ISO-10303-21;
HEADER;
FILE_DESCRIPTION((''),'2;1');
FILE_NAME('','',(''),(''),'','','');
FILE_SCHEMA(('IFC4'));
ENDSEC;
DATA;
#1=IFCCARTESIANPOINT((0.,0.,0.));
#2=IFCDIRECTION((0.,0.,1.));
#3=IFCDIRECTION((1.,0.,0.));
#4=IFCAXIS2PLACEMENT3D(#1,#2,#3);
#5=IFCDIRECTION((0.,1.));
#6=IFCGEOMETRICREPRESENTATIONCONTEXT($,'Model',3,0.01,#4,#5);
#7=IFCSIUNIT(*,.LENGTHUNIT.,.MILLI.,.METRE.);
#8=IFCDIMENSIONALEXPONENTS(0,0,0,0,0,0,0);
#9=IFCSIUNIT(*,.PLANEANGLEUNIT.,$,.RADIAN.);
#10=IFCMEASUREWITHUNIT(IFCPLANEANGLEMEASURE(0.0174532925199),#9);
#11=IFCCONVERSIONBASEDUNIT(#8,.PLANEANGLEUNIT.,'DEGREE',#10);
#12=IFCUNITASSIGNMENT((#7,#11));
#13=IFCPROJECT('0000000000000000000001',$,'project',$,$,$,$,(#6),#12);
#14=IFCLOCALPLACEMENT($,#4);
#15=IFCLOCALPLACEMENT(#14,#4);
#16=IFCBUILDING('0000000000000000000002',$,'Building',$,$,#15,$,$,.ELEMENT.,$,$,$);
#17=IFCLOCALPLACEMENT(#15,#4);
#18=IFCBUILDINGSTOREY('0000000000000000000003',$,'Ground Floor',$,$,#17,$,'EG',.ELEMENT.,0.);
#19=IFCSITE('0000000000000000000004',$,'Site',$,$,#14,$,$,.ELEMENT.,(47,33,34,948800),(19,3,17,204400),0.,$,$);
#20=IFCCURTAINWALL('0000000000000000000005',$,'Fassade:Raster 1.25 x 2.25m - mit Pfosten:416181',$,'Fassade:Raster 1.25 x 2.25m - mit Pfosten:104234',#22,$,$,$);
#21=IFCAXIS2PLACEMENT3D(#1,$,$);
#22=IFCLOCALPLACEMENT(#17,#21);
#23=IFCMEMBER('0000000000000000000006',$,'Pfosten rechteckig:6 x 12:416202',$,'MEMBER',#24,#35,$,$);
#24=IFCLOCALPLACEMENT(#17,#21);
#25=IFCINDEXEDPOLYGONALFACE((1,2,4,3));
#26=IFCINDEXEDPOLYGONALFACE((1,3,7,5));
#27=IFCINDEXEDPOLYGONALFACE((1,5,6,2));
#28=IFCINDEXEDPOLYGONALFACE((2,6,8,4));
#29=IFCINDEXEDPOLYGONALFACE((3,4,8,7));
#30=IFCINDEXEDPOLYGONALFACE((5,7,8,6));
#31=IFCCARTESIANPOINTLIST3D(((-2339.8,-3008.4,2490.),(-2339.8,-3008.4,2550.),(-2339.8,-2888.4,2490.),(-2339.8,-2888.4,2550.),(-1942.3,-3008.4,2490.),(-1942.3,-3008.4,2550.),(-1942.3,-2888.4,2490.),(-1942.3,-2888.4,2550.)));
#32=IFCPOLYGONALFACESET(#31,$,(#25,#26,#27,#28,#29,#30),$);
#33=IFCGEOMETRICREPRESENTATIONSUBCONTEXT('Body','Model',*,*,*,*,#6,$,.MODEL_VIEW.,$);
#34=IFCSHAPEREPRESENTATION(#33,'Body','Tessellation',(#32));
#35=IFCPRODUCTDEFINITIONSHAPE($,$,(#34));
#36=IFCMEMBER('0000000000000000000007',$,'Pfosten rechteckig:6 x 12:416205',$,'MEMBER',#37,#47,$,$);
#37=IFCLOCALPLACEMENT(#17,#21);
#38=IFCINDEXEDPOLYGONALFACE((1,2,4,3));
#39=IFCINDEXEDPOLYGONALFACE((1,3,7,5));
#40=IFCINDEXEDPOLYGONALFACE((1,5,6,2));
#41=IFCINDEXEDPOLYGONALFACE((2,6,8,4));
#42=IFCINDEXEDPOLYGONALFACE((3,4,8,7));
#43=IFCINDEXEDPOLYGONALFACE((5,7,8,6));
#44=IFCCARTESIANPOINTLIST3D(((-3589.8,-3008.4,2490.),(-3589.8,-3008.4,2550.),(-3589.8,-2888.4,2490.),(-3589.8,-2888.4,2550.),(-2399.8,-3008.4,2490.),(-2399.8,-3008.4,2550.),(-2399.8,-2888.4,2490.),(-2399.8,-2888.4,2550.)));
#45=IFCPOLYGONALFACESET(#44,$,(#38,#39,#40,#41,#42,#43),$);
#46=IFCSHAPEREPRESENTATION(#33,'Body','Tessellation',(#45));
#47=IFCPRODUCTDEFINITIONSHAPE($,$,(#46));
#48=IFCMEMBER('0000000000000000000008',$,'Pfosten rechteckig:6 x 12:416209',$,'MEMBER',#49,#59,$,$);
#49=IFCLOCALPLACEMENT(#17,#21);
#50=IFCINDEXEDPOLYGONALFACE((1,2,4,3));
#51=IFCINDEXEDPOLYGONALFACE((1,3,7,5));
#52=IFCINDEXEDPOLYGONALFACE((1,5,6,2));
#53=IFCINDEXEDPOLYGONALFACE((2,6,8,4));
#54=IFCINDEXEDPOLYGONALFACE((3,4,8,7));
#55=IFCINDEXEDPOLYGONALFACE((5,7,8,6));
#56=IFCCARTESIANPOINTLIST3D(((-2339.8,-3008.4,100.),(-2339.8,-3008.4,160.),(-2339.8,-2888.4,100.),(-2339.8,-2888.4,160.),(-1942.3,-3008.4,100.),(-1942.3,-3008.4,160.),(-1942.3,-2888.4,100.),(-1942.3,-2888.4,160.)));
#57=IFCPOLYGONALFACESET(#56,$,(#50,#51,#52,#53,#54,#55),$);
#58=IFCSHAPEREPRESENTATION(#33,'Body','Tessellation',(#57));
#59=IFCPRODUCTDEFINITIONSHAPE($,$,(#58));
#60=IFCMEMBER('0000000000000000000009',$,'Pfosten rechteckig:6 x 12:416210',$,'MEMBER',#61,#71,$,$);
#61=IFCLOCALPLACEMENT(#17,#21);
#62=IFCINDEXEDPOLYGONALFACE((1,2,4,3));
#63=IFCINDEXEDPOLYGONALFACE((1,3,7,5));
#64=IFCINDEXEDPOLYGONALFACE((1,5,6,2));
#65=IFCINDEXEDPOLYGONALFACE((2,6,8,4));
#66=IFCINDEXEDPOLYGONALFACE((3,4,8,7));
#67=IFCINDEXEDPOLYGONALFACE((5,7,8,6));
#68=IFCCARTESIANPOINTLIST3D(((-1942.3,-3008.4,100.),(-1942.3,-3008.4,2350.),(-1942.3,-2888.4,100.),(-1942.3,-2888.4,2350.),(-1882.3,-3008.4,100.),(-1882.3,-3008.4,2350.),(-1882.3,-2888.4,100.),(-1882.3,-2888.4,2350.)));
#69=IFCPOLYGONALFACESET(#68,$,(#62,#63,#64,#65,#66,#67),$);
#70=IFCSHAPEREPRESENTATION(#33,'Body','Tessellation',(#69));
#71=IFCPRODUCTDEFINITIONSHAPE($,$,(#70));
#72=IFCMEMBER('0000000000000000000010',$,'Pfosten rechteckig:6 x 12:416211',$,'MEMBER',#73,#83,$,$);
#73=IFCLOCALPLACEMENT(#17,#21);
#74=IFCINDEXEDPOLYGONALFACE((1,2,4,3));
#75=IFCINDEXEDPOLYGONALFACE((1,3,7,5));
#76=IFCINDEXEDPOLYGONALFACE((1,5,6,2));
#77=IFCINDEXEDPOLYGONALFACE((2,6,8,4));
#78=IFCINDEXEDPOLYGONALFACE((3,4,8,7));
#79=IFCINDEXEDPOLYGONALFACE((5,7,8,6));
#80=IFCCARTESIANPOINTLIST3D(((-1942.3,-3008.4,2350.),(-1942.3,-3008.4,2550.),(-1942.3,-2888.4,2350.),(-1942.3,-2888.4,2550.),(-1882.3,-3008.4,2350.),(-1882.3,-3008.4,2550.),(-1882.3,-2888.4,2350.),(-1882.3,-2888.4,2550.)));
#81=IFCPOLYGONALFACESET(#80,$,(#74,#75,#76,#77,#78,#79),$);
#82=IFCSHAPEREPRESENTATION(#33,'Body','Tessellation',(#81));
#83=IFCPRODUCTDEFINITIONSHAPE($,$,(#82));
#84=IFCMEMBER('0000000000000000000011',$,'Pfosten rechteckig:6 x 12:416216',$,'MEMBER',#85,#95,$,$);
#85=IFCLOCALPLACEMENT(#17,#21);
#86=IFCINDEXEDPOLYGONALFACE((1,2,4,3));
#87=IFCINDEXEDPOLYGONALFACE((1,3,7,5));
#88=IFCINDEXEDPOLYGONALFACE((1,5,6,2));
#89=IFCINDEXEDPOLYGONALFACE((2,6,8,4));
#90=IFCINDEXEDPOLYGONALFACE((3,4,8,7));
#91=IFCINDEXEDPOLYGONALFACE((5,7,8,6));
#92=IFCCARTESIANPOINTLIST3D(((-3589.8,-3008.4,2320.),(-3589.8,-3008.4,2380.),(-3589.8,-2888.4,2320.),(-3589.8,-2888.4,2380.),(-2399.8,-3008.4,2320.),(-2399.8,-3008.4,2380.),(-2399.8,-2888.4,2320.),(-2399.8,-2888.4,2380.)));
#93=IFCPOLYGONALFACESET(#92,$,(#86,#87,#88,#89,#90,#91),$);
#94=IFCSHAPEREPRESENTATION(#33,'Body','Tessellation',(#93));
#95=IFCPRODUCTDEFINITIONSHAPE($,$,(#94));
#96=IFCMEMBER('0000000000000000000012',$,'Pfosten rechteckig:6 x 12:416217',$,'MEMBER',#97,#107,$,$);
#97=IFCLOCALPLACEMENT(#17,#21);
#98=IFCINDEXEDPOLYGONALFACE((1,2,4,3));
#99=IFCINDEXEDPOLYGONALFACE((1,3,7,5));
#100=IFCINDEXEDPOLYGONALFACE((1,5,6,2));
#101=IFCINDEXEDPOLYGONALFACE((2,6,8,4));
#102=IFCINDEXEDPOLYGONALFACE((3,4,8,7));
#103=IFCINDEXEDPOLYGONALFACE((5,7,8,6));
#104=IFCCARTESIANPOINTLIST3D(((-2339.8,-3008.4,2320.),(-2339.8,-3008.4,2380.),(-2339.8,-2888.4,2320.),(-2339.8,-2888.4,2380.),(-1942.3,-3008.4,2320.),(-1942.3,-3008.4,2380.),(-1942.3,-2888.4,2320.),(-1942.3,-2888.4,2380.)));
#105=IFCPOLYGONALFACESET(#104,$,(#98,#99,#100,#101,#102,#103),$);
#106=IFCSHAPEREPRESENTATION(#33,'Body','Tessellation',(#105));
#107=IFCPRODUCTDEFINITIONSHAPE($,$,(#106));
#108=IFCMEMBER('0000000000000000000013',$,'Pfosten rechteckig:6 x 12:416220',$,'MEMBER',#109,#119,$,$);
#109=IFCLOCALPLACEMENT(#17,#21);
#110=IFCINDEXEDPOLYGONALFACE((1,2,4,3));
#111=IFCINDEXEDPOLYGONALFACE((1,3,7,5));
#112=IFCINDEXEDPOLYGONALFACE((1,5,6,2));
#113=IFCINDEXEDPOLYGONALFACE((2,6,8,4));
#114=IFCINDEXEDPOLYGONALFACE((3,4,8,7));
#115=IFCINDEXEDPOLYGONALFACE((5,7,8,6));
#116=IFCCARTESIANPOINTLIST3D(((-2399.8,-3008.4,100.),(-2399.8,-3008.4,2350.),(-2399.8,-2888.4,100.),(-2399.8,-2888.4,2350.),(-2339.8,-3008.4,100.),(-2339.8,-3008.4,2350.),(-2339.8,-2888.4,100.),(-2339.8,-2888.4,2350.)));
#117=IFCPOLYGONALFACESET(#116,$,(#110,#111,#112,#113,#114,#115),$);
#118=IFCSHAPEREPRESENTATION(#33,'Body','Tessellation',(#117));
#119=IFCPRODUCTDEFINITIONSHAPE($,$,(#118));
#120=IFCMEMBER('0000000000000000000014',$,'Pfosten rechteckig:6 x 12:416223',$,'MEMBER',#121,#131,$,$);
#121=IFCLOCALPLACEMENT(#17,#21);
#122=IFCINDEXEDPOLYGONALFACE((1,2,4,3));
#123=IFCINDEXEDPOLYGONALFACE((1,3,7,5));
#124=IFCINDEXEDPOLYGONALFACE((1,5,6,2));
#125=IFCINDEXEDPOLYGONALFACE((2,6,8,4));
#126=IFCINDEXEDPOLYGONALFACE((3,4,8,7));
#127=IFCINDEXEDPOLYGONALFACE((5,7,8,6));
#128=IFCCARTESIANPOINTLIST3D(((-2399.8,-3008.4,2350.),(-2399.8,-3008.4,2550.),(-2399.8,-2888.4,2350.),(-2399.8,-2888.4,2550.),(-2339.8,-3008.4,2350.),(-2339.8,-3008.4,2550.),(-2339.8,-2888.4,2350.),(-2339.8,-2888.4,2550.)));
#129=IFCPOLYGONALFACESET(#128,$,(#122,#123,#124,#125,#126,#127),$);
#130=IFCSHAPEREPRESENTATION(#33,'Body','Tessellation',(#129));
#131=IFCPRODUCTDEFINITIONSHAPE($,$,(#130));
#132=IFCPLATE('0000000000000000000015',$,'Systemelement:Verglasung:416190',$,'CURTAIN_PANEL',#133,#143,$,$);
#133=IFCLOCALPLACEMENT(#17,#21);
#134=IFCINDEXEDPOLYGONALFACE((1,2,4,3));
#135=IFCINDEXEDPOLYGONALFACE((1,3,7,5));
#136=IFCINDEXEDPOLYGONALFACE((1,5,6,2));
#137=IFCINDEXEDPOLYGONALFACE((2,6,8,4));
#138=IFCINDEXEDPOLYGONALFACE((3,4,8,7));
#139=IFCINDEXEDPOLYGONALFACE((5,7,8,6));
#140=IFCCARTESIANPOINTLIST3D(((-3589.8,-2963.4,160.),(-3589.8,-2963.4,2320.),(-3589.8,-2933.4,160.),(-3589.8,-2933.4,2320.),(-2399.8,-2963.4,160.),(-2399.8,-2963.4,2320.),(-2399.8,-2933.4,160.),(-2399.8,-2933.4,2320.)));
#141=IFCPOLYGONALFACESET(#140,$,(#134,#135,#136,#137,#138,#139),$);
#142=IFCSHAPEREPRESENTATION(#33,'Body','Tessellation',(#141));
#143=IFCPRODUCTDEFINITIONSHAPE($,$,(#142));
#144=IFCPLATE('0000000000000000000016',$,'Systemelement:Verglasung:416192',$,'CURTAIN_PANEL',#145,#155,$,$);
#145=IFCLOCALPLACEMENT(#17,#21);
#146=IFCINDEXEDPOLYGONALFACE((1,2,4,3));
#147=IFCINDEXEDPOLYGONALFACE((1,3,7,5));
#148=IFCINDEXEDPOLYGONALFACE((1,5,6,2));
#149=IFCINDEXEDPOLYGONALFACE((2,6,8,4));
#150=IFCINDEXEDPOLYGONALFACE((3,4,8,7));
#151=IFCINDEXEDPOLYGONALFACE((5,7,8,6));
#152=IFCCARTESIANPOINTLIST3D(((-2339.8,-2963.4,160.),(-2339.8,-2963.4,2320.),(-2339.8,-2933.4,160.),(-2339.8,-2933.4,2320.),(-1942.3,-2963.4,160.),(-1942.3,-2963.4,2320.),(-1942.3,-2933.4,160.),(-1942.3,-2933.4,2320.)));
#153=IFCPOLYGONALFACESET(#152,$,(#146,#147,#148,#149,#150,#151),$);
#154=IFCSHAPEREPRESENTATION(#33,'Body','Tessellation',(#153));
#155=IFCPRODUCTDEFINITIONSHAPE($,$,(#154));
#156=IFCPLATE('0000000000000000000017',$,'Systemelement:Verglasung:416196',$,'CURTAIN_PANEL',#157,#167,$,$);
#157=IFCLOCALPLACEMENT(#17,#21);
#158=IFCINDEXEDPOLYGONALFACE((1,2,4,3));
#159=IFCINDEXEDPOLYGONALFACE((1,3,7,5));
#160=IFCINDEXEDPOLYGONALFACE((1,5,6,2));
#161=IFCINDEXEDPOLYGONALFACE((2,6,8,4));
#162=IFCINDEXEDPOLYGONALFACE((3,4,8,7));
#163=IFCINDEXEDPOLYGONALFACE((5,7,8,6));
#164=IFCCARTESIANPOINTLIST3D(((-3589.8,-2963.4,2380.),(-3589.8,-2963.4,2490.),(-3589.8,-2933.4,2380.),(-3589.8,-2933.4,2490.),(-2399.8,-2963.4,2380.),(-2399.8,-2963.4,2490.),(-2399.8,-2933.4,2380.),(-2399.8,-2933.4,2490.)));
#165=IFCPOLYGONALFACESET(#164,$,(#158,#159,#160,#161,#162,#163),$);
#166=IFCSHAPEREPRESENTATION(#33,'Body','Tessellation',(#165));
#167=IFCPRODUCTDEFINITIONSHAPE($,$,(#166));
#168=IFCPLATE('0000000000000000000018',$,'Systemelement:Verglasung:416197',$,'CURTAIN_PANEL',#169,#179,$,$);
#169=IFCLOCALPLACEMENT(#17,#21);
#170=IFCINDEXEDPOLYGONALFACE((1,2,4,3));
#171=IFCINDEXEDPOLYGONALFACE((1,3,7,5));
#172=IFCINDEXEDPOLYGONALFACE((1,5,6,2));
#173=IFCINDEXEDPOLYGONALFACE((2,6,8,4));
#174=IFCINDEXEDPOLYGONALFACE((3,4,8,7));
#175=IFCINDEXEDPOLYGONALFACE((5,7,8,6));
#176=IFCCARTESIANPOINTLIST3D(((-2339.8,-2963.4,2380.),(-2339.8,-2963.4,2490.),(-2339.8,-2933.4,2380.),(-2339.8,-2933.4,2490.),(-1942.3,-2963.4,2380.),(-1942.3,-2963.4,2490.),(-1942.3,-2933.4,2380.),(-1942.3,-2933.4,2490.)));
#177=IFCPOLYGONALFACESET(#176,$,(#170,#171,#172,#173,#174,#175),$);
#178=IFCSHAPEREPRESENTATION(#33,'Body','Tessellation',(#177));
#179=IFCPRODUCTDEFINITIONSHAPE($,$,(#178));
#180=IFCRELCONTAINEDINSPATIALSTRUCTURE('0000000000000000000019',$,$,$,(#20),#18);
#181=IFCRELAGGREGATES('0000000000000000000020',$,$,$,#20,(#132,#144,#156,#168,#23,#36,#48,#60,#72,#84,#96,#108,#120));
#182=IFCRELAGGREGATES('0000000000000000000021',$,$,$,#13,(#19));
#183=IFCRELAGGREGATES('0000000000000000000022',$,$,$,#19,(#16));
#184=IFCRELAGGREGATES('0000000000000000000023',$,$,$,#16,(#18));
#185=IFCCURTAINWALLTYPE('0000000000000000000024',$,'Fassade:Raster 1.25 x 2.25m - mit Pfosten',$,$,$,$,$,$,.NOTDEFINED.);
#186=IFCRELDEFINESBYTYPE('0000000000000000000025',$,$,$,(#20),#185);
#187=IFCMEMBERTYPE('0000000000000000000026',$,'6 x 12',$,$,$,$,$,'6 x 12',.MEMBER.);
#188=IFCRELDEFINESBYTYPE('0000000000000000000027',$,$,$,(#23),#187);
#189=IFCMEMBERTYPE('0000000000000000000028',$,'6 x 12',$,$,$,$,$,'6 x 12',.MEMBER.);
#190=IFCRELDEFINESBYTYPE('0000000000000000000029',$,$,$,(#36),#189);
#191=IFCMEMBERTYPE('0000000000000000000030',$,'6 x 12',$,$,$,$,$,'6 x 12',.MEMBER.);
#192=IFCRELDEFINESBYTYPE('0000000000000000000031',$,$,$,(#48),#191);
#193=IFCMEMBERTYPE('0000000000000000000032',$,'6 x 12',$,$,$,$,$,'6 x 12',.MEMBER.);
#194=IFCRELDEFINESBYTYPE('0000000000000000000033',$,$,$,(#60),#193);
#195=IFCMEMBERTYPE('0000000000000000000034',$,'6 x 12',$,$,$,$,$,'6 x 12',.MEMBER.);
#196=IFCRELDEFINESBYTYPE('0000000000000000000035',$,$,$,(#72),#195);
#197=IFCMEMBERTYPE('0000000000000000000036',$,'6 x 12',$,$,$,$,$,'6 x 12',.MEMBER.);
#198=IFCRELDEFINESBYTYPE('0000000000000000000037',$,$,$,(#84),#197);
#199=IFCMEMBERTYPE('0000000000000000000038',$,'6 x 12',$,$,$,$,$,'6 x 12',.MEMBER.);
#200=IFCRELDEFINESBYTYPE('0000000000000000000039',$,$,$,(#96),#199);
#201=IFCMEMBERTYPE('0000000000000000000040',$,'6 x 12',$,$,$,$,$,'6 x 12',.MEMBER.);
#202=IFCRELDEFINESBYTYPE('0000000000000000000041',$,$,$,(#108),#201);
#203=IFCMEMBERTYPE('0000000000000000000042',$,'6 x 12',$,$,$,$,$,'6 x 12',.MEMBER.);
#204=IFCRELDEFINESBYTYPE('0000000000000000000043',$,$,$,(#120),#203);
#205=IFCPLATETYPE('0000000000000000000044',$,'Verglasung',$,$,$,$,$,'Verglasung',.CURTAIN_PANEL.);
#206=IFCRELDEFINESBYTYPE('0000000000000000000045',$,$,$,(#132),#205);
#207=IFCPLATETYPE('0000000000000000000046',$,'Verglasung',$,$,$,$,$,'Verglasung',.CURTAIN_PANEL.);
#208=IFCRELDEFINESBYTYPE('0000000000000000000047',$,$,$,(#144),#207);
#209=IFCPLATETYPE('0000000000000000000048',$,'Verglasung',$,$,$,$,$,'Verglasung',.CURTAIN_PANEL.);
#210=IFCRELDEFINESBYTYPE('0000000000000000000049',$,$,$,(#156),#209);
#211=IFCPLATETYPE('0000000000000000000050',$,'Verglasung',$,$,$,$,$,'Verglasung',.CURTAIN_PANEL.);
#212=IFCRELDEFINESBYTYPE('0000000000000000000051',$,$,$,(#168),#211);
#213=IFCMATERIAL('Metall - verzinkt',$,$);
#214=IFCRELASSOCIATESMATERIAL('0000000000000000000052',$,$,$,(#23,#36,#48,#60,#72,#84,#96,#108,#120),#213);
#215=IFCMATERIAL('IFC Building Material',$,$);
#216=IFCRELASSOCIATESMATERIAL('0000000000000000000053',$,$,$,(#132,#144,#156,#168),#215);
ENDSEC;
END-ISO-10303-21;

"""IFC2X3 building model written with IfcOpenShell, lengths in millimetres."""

from ifc_helpers import new_model, entity, si_unit, converted_unit, direction, frame, origin_with_axes, origin_2d_with_axis, place, context, subcontext, project, spatial, rectangle, extrude, material, type_object, element, aggregate, save


model = new_model("IFC2X3")

# Units and contexts
model_context = context("Model", 3, precision=0.01, world=origin_with_axes(), true_north=direction((0.0, 1.0)))
body_context = subcontext(model_context, "Body", "Model", "MODEL_VIEW")
ifc_project = project(units=[si_unit("LENGTHUNIT", "METRE", prefix="MILLI"), converted_unit("PLANEANGLEUNIT", "DEGREE", entity("IfcPlaneAngleMeasure", 0.0174532925199), si_unit("PLANEANGLEUNIT", "RADIAN"), dimensions=[0, 0, 0, 0, 0, 0, 0])], contexts=[model_context])

# Site, building, storey
site_placement = place(None, origin_with_axes())
site = spatial("IfcSite", under=ifc_project, at=site_placement, Name="Site", CompositionType="ELEMENT", RefLatitude=(47, 33, 34, 948800), RefLongitude=(19, 3, 17, 204400), RefElevation=0.0)
building_placement = place(site_placement, origin_with_axes())
building = spatial("IfcBuilding", under=site, at=building_placement, Name="Building", CompositionType="ELEMENT")
storey_placement = place(building_placement, origin_with_axes())
storey = spatial("IfcBuildingStorey", under=building, at=storey_placement, Name="Ground Floor", LongName="EG", CompositionType="ELEMENT", Elevation=0.0)

# Curtain wall, members, plates
curtain_wall_type = type_object("IfcCurtainWallType", Name="Fassade:Raster 1.25 x 2.25m - mit Pfosten", PredefinedType="NOTDEFINED")
curtain_wall_placement = place(storey_placement, origin_with_axes())
curtain_wall = element("IfcCurtainWall", 1, at=curtain_wall_placement, inside=storey, type_object=curtain_wall_type, Name="Fassade:Raster 1.25 x 2.25m - mit Pfosten:416181", ObjectType="Fassade:Raster 1.25 x 2.25m - mit Pfosten:104234")
ifc_material_1 = material(Name="Metall - verzinkt")
member_type_1 = type_object("IfcMemberType", Name="6 x 12", ElementType="6 x 12", PredefinedType="MEMBER")
member_1_placement = place(curtain_wall_placement, frame((-1942.3, -2948.4, 2550.0), z_axis=(0.0, 0.0, 1.0), x_axis=(0.0, -1.0, 0.0)))
member_1 = element("IfcMember", 2, at=member_1_placement, type_object=member_type_1, material=ifc_material_1, Name="Pfosten rechteckig:6 x 12:416202", ObjectType="MEMBER", context=body_context, shape_type="SweptSolid", body=[
    extrude(rectangle(XDim=120.0, YDim=60.0, at=origin_2d_with_axis()), frame((0.0, -397.5, -30.0), z_axis=(0.0, 1.0, 0.0), x_axis=(-1.0, 0.0, 0.0)), (0.0, 0.0, 1.0), 397.5),
])
member_type_2 = type_object("IfcMemberType", Name="6 x 12", ElementType="6 x 12", PredefinedType="MEMBER")
member_2_placement = place(curtain_wall_placement, frame((-2399.8, -2948.4, 2550.0), z_axis=(0.0, 0.0, 1.0), x_axis=(0.0, -1.0, 0.0)))
member_2 = element("IfcMember", 3, at=member_2_placement, type_object=member_type_2, material=ifc_material_1, Name="Pfosten rechteckig:6 x 12:416205", ObjectType="MEMBER", context=body_context, shape_type="SweptSolid", body=[
    extrude(rectangle(XDim=120.0, YDim=60.0, at=origin_2d_with_axis()), frame((0.0, -1190.0, -30.0), z_axis=(0.0, 1.0, 0.0), x_axis=(-1.0, 0.0, 0.0)), (0.0, 0.0, 1.0), 1190.0),
])
member_type_3 = type_object("IfcMemberType", Name="6 x 12", ElementType="6 x 12", PredefinedType="MEMBER")
member_3_placement = place(curtain_wall_placement, frame((-2339.8, -2948.4, 100.0), z_axis=(0.0, 0.0, 1.0), x_axis=(0.0, -1.0, 0.0)))
member_3 = element("IfcMember", 4, at=member_3_placement, type_object=member_type_3, material=ifc_material_1, Name="Pfosten rechteckig:6 x 12:416209", ObjectType="MEMBER", context=body_context, shape_type="SweptSolid", body=[
    extrude(rectangle(XDim=120.0, YDim=60.0, at=origin_2d_with_axis()), frame((0.0, 397.5, 30.0), z_axis=(0.0, -1.0, 0.0), x_axis=(-1.0, 0.0, 0.0)), (0.0, 0.0, 1.0), 397.5),
])
member_type_4 = type_object("IfcMemberType", Name="6 x 12", ElementType="6 x 12", PredefinedType="MEMBER")
member_4_placement = place(curtain_wall_placement, frame((-1882.3, -2948.4, 100.0), z_axis=(0.0, 0.0, 1.0), x_axis=(1.0, 0.0, 0.0)))
member_4 = element("IfcMember", 5, at=member_4_placement, type_object=member_type_4, material=ifc_material_1, Name="Pfosten rechteckig:6 x 12:416210", ObjectType="MEMBER", context=body_context, shape_type="SweptSolid", body=[
    extrude(rectangle(XDim=120.0, YDim=60.0, at=origin_2d_with_axis()), frame((-30.0, 0.0, 2250.0), z_axis=(0.0, 0.0, -1.0), x_axis=(0.0, 1.0, 0.0)), (0.0, 0.0, 1.0), 2250.0),
])
member_type_5 = type_object("IfcMemberType", Name="6 x 12", ElementType="6 x 12", PredefinedType="MEMBER")
member_5_placement = place(curtain_wall_placement, frame((-1882.3, -2948.4, 2350.0), z_axis=(0.0, 0.0, 1.0), x_axis=(1.0, 0.0, 0.0)))
member_5 = element("IfcMember", 6, at=member_5_placement, type_object=member_type_5, material=ifc_material_1, Name="Pfosten rechteckig:6 x 12:416211", ObjectType="MEMBER", context=body_context, shape_type="SweptSolid", body=[
    extrude(rectangle(XDim=120.0, YDim=60.0, at=origin_2d_with_axis()), frame((-30.0, 0.0, 200.0), z_axis=(0.0, 0.0, -1.0), x_axis=(0.0, 1.0, 0.0)), (0.0, 0.0, 1.0), 200.0),
])
member_type_6 = type_object("IfcMemberType", Name="6 x 12", ElementType="6 x 12", PredefinedType="MEMBER")
member_6_placement = place(curtain_wall_placement, frame((-2399.8, -2948.4, 2350.0), z_axis=(0.0, 0.0, 1.0), x_axis=(0.0, -1.0, 0.0)))
member_6 = element("IfcMember", 7, at=member_6_placement, type_object=member_type_6, material=ifc_material_1, Name="Pfosten rechteckig:6 x 12:416216", ObjectType="MEMBER", context=body_context, shape_type="SweptSolid", body=[
    extrude(rectangle(XDim=120.0, YDim=60.0, at=origin_2d_with_axis()), frame((0.0, -1190.0, 0.0), z_axis=(0.0, 1.0, 0.0), x_axis=(-1.0, 0.0, 0.0)), (0.0, 0.0, 1.0), 1190.0),
])
member_type_7 = type_object("IfcMemberType", Name="6 x 12", ElementType="6 x 12", PredefinedType="MEMBER")
member_7_placement = place(curtain_wall_placement, frame((-1942.3, -2948.4, 2350.0), z_axis=(0.0, 0.0, 1.0), x_axis=(0.0, -1.0, 0.0)))
member_7 = element("IfcMember", 8, at=member_7_placement, type_object=member_type_7, material=ifc_material_1, Name="Pfosten rechteckig:6 x 12:416217", ObjectType="MEMBER", context=body_context, shape_type="SweptSolid", body=[
    extrude(rectangle(XDim=120.0, YDim=60.0, at=origin_2d_with_axis()), frame((0.0, -397.5, 0.0), z_axis=(0.0, 1.0, 0.0), x_axis=(-1.0, 0.0, 0.0)), (0.0, 0.0, 1.0), 397.5),
])
member_type_8 = type_object("IfcMemberType", Name="6 x 12", ElementType="6 x 12", PredefinedType="MEMBER")
member_8_placement = place(curtain_wall_placement, frame((-2369.8, -2948.4, 100.0), z_axis=(0.0, 0.0, 1.0), x_axis=(1.0, 0.0, 0.0)))
member_8 = element("IfcMember", 9, at=member_8_placement, type_object=member_type_8, material=ifc_material_1, Name="Pfosten rechteckig:6 x 12:416220", ObjectType="MEMBER", context=body_context, shape_type="SweptSolid", body=[
    extrude(rectangle(XDim=120.0, YDim=60.0, at=origin_2d_with_axis()), frame((0.0, 0.0, 2250.0), z_axis=(0.0, 0.0, -1.0), x_axis=(0.0, 1.0, 0.0)), (0.0, 0.0, 1.0), 2250.0),
])
member_type_9 = type_object("IfcMemberType", Name="6 x 12", ElementType="6 x 12", PredefinedType="MEMBER")
member_9_placement = place(curtain_wall_placement, frame((-2369.8, -2948.4, 2350.0), z_axis=(0.0, 0.0, 1.0), x_axis=(1.0, 0.0, 0.0)))
member_9 = element("IfcMember", 10, at=member_9_placement, type_object=member_type_9, material=ifc_material_1, Name="Pfosten rechteckig:6 x 12:416223", ObjectType="MEMBER", context=body_context, shape_type="SweptSolid", body=[
    extrude(rectangle(XDim=120.0, YDim=60.0, at=origin_2d_with_axis()), frame((0.0, 0.0, 200.0), z_axis=(0.0, 0.0, -1.0), x_axis=(0.0, 1.0, 0.0)), (0.0, 0.0, 1.0), 200.0),
])
ifc_material_2 = material(Name="IFC Building Material")
plate_type_1 = type_object("IfcPlateType", Name="Verglasung", ElementType="Verglasung", PredefinedType="CURTAIN_PANEL")
plate_1_placement = place(curtain_wall_placement, frame((-2994.8, -2948.4, 160.0), z_axis=(0.0, 0.0, 1.0), x_axis=(1.0, 0.0, 0.0)))
plate_1 = element("IfcPlate", 11, at=plate_1_placement, type_object=plate_type_1, material=ifc_material_2, Name="Systemelement:Verglasung:416190", ObjectType="CURTAIN_PANEL", context=body_context, shape_type="SweptSolid", body=[
    extrude(rectangle(XDim=30.0, YDim=1190.0, at=origin_2d_with_axis()), frame((0.0, 0.0, 0.0), z_axis=(0.0, 0.0, 1.0), x_axis=(0.0, 1.0, 0.0)), (0.0, 0.0, 1.0), 2160.0),
])
plate_type_2 = type_object("IfcPlateType", Name="Verglasung", ElementType="Verglasung", PredefinedType="CURTAIN_PANEL")
plate_2_placement = place(curtain_wall_placement, frame((-2141.0, -2948.4, 160.0), z_axis=(0.0, 0.0, 1.0), x_axis=(1.0, 0.0, 0.0)))
plate_2 = element("IfcPlate", 12, at=plate_2_placement, type_object=plate_type_2, material=ifc_material_2, Name="Systemelement:Verglasung:416192", ObjectType="CURTAIN_PANEL", context=body_context, shape_type="SweptSolid", body=[
    extrude(rectangle(XDim=30.0, YDim=397.5, at=origin_2d_with_axis()), frame((0.0, 0.0, 0.0), z_axis=(0.0, 0.0, 1.0), x_axis=(0.0, 1.0, 0.0)), (0.0, 0.0, 1.0), 2160.0),
])
plate_type_3 = type_object("IfcPlateType", Name="Verglasung", ElementType="Verglasung", PredefinedType="CURTAIN_PANEL")
plate_3_placement = place(curtain_wall_placement, frame((-2994.8, -2948.4, 2380.0), z_axis=(0.0, 0.0, 1.0), x_axis=(1.0, 0.0, 0.0)))
plate_3 = element("IfcPlate", 13, at=plate_3_placement, type_object=plate_type_3, material=ifc_material_2, Name="Systemelement:Verglasung:416196", ObjectType="CURTAIN_PANEL", context=body_context, shape_type="SweptSolid", body=[
    extrude(rectangle(XDim=30.0, YDim=1190.0, at=origin_2d_with_axis()), frame((0.0, 0.0, 0.0), z_axis=(0.0, 0.0, 1.0), x_axis=(0.0, 1.0, 0.0)), (0.0, 0.0, 1.0), 110.0),
])
plate_type_4 = type_object("IfcPlateType", Name="Verglasung", ElementType="Verglasung", PredefinedType="CURTAIN_PANEL")
plate_4_placement = place(curtain_wall_placement, frame((-2141.0, -2948.4, 2380.0), z_axis=(0.0, 0.0, 1.0), x_axis=(1.0, 0.0, 0.0)))
plate_4 = element("IfcPlate", 14, at=plate_4_placement, type_object=plate_type_4, material=ifc_material_2, Name="Systemelement:Verglasung:416197", ObjectType="CURTAIN_PANEL", context=body_context, shape_type="SweptSolid", body=[
    extrude(rectangle(XDim=30.0, YDim=397.5, at=origin_2d_with_axis()), frame((0.0, 0.0, 0.0), z_axis=(0.0, 0.0, 1.0), x_axis=(0.0, 1.0, 0.0)), (0.0, 0.0, 1.0), 110.0),
])
aggregate(curtain_wall, [plate_1, plate_2, plate_3, plate_4, member_1, member_2, member_3, member_4, member_5, member_6, member_7, member_8, member_9])

save(model, "model.ifc")
